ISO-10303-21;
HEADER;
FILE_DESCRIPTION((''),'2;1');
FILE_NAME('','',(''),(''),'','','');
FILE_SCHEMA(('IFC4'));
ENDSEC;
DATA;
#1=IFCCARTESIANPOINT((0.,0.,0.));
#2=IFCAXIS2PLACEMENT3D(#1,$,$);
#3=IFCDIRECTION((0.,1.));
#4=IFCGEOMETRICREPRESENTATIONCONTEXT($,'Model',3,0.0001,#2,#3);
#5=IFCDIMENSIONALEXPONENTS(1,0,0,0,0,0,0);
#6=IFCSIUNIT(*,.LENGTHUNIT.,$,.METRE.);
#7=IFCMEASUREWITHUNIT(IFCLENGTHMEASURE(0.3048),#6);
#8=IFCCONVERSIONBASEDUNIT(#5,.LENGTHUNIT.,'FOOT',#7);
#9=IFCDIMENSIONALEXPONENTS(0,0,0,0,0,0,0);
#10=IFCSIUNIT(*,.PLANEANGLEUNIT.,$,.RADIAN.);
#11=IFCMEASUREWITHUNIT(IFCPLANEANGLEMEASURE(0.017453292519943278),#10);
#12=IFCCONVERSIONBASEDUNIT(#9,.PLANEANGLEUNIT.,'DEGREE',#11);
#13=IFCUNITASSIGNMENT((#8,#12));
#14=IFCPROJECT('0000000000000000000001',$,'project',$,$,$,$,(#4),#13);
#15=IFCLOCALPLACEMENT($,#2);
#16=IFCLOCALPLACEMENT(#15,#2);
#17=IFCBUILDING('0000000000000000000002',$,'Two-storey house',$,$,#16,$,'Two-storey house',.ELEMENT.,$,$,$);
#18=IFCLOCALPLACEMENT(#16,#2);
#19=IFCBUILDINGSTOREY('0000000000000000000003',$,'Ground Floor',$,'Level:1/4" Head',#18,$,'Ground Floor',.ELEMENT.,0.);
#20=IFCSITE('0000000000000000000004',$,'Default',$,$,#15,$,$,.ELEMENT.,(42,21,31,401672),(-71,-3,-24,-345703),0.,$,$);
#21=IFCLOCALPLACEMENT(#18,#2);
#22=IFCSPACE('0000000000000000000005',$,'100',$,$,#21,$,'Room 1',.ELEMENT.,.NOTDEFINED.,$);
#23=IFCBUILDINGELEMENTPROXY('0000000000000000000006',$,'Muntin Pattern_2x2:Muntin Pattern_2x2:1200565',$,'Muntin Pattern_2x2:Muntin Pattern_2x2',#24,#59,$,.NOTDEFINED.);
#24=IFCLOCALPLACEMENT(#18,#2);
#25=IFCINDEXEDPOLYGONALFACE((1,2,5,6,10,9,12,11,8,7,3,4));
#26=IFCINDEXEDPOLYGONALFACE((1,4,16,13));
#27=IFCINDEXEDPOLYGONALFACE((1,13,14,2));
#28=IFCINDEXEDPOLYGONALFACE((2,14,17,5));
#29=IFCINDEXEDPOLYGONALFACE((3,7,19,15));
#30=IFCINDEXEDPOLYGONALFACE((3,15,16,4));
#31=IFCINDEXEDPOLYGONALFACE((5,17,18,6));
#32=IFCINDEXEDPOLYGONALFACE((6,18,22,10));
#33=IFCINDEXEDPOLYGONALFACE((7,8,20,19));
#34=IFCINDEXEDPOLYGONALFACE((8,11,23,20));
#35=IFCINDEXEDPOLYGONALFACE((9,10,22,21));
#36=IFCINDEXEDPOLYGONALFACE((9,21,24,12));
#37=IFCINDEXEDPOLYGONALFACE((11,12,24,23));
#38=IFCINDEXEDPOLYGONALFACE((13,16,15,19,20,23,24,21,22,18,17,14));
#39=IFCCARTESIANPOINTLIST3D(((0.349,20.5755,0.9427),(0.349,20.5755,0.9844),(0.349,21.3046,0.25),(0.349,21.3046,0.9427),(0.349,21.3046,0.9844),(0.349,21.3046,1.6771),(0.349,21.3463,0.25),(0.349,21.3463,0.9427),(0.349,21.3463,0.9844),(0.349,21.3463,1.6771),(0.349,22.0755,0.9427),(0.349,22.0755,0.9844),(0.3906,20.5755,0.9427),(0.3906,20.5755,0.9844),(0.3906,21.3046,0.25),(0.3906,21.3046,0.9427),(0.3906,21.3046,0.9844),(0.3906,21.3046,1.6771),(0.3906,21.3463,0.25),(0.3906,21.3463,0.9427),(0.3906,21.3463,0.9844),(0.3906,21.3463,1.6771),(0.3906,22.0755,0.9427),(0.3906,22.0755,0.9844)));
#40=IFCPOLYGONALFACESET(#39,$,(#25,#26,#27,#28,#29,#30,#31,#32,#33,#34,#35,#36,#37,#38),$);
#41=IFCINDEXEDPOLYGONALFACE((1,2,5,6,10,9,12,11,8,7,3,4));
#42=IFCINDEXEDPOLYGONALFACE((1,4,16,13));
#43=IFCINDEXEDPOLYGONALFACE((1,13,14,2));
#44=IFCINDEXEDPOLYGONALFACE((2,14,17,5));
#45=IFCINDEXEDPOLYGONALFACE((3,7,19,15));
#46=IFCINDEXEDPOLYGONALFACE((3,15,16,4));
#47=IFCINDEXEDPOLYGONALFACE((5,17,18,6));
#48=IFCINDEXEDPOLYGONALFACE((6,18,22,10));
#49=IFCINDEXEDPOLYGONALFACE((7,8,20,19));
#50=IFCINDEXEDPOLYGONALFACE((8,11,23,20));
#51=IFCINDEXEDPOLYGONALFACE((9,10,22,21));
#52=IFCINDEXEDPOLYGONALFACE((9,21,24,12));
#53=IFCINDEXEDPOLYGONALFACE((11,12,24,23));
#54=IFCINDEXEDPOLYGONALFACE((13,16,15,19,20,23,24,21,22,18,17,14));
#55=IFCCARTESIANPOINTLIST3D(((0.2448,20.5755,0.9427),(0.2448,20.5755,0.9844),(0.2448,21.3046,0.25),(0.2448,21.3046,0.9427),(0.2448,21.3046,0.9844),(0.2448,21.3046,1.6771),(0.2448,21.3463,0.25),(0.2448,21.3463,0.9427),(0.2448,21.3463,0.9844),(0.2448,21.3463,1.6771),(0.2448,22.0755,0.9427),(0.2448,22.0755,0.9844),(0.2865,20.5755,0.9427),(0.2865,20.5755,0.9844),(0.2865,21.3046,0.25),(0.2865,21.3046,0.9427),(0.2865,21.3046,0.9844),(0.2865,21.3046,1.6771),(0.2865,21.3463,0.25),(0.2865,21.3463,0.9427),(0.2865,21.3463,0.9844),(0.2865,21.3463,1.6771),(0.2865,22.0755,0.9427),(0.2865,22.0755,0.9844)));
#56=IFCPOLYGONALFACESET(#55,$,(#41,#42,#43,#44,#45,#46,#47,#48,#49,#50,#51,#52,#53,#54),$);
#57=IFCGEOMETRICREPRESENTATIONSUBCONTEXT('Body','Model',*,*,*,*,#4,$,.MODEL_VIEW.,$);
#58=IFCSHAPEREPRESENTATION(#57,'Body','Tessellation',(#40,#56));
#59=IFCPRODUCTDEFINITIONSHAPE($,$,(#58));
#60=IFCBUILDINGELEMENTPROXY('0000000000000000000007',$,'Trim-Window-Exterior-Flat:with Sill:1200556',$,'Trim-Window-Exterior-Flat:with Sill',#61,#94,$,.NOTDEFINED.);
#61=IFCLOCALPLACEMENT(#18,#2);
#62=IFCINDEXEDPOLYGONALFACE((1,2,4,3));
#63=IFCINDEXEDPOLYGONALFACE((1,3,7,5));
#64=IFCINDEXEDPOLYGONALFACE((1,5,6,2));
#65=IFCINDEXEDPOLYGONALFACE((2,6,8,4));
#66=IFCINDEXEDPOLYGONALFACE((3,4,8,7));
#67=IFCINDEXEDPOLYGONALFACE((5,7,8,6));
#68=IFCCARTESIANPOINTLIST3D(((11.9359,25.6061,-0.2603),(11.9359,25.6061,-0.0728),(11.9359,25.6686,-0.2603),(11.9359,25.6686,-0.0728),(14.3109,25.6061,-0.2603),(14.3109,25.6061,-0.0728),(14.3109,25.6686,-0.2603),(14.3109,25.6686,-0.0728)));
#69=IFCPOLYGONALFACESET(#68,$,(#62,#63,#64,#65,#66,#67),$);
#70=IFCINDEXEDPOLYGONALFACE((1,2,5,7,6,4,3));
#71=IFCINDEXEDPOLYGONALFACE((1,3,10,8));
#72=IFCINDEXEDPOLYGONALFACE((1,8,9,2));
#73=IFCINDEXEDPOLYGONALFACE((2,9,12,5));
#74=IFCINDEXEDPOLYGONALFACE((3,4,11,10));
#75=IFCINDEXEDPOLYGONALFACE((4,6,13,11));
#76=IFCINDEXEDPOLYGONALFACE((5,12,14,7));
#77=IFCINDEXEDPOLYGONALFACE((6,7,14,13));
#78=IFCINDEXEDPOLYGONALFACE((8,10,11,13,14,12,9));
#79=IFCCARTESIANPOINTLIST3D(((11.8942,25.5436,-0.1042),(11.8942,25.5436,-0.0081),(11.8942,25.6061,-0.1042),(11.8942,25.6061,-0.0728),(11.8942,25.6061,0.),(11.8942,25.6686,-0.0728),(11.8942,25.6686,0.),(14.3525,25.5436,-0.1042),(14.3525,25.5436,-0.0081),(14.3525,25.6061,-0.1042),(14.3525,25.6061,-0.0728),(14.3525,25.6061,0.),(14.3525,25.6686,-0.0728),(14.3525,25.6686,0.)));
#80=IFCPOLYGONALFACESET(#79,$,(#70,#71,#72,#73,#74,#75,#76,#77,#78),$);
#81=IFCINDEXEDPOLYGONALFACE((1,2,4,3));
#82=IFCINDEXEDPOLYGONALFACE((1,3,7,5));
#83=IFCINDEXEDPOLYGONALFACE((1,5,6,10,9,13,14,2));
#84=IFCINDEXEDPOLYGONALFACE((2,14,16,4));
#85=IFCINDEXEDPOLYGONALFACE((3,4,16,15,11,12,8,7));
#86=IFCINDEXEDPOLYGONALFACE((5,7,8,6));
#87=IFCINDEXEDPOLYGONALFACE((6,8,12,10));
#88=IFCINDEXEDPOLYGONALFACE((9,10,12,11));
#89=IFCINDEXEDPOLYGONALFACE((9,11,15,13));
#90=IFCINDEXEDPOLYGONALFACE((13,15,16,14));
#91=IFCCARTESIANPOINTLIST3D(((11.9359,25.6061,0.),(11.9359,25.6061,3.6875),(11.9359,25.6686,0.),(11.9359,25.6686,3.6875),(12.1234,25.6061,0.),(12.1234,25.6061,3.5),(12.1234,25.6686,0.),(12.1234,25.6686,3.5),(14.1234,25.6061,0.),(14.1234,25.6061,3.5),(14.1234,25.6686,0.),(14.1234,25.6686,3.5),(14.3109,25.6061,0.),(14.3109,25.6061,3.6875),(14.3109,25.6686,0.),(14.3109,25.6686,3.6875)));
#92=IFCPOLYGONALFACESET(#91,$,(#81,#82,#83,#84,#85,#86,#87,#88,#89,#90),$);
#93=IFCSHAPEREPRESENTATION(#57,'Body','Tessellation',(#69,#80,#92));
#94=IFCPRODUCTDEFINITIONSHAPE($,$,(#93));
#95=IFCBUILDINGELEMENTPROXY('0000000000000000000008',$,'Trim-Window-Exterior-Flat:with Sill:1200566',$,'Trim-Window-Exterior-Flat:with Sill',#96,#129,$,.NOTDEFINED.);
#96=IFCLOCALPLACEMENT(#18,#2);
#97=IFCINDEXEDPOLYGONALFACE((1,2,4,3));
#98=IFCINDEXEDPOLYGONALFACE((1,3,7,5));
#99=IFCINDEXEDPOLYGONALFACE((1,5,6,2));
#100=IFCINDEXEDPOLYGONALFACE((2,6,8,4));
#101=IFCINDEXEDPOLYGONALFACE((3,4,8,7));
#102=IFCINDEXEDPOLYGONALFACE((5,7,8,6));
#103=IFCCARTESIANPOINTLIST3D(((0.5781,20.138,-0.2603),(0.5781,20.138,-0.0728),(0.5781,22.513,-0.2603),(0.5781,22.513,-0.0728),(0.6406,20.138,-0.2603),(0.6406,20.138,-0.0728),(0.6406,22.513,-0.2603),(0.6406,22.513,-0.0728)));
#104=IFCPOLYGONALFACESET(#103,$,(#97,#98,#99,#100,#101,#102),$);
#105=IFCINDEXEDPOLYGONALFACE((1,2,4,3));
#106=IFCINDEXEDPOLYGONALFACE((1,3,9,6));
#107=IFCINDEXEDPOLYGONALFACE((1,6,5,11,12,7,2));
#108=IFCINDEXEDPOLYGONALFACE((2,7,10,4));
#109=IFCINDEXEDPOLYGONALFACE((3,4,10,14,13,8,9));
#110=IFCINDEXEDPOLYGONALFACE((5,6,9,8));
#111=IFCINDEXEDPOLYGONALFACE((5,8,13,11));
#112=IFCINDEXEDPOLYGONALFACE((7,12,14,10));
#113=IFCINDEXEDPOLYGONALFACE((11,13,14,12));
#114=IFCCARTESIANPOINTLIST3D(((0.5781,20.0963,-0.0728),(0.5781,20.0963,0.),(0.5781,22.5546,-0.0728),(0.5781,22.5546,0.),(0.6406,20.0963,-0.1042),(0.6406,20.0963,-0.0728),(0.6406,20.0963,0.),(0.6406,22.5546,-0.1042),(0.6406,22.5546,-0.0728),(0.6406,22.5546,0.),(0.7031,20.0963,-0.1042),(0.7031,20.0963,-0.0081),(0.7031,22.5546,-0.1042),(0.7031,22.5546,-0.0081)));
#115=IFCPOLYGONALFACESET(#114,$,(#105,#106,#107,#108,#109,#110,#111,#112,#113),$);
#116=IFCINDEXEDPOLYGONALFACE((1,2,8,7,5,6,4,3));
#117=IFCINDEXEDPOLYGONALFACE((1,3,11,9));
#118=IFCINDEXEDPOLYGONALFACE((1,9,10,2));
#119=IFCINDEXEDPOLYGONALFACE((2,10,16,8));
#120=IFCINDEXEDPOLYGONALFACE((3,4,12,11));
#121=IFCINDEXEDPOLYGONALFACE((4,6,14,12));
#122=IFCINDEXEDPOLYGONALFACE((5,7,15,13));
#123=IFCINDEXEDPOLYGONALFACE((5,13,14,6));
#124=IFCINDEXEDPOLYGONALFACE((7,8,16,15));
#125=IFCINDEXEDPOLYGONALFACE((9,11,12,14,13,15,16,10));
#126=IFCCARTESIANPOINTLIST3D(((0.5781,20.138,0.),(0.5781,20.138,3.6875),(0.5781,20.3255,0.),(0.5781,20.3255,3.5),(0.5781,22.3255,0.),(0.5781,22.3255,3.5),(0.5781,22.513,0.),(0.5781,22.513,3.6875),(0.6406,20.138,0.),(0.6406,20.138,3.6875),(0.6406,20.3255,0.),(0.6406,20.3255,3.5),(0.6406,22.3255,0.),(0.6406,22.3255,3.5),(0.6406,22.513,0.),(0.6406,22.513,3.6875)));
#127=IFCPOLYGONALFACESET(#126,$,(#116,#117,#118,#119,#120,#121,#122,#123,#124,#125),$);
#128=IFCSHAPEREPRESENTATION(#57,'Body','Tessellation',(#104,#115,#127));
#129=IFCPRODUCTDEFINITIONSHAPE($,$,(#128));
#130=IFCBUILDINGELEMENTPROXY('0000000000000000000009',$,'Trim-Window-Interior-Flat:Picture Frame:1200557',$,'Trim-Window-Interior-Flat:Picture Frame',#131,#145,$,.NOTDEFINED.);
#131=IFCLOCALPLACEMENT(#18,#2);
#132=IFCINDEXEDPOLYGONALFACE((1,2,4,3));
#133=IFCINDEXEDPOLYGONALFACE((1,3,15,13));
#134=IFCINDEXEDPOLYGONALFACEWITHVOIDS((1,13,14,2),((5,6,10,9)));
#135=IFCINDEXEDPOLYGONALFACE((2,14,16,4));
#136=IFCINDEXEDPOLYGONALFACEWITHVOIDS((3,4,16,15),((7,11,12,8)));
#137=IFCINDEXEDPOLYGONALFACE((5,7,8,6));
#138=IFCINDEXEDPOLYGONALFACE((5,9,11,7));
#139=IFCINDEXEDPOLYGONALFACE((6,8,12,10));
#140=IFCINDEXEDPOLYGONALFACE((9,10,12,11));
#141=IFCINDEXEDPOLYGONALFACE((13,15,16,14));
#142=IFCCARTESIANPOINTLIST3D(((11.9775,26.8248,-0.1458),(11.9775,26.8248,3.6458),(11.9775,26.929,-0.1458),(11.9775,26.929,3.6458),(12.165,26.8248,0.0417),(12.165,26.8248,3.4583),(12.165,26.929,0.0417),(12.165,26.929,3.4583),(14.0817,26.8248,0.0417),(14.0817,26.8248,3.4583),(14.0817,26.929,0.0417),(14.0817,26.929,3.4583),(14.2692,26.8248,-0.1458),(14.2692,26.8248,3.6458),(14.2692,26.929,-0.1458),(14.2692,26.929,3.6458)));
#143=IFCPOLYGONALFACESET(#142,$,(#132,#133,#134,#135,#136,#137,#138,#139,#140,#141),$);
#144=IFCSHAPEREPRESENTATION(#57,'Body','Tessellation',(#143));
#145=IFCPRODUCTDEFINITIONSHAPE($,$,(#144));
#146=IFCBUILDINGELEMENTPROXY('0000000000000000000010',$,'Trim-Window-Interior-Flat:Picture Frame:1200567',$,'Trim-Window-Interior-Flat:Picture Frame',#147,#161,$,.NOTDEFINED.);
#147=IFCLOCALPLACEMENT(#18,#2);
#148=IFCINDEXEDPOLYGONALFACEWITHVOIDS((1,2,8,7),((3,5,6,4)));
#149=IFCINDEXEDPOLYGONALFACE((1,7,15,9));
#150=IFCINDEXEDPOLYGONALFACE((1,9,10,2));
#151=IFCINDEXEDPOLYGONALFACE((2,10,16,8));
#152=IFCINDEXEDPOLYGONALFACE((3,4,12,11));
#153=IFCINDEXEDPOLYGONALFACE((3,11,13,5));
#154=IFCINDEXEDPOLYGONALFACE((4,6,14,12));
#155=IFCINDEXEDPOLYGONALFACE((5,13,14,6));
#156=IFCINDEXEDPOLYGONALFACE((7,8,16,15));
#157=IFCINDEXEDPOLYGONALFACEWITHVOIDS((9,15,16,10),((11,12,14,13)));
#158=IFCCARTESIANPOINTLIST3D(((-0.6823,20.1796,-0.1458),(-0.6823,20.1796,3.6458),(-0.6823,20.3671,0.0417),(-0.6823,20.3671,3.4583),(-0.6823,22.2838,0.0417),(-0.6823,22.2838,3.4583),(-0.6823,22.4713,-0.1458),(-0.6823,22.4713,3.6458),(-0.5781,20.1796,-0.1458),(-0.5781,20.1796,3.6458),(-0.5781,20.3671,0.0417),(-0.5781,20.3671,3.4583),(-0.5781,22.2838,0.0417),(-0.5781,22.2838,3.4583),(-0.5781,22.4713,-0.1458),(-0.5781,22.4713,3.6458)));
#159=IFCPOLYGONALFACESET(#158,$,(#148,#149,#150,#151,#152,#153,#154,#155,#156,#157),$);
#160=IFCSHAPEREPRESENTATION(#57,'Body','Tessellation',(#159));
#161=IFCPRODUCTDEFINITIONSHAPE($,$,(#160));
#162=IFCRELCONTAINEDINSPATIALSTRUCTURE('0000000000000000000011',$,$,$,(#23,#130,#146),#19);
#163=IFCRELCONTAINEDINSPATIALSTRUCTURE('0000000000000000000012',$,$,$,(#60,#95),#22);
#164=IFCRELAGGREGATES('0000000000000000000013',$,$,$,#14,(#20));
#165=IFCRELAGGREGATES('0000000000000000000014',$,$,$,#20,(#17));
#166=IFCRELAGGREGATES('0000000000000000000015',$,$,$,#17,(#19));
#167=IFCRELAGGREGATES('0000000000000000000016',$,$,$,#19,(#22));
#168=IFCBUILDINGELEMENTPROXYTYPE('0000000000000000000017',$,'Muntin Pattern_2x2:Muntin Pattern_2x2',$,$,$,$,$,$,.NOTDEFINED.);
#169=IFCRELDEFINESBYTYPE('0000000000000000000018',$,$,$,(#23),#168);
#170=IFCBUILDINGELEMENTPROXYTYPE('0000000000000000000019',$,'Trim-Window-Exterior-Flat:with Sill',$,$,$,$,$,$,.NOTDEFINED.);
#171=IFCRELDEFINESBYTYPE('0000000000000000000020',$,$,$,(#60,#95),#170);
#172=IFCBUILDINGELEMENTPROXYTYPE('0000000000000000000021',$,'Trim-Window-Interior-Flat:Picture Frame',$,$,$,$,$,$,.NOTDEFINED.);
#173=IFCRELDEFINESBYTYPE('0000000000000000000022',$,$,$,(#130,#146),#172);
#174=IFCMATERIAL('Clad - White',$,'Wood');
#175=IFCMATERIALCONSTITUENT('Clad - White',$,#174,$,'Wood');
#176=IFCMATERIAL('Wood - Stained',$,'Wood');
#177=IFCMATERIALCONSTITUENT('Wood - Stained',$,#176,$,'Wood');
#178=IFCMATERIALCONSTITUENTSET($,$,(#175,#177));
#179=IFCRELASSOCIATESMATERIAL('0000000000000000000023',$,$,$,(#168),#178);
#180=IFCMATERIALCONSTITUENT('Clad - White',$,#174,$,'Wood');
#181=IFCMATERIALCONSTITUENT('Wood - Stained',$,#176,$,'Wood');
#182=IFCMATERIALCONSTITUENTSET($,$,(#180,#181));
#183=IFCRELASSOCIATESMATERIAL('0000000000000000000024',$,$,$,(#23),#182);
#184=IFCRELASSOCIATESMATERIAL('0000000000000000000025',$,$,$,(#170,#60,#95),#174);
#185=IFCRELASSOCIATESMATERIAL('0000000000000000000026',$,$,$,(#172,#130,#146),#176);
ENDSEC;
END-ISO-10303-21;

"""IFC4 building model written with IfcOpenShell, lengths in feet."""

from ifc_helpers import new_model, entity, si_unit, converted_unit, direction, frame, origin, place, context, subcontext, project, spatial, indexed_curve, outline, extrude, source, transform, mapped, material, constituent, constituent_set, type_object, type_shapes, element, save


model = new_model("IFC4")

# Units and contexts
model_context = context("Model", 3, precision=0.0001, world=origin(), true_north=direction((0.0, 1.0)))
body_context = subcontext(model_context, "Body", "Model", "MODEL_VIEW")
ifc_project = project(units=[converted_unit("LENGTHUNIT", "FOOT", entity("IfcLengthMeasure", 0.3048), si_unit("LENGTHUNIT", "METRE"), dimensions=[1, 0, 0, 0, 0, 0, 0]), converted_unit("PLANEANGLEUNIT", "DEGREE", entity("IfcPlaneAngleMeasure", 0.017453292519943278), si_unit("PLANEANGLEUNIT", "RADIAN"), dimensions=[0, 0, 0, 0, 0, 0, 0])], contexts=[model_context])

# Site, building, storey
site_placement = place(None, origin())
site = spatial("IfcSite", under=ifc_project, at=site_placement, Name="Default", CompositionType="ELEMENT", RefLatitude=(42, 21, 31, 401672), RefLongitude=(-71, -3, -24, -345703), RefElevation=0.0)
building_placement = place(site_placement, origin())
building = spatial("IfcBuilding", under=site, at=building_placement, Name="Two-storey house", LongName="Two-storey house", CompositionType="ELEMENT")
storey_placement = place(building_placement, origin())
storey = spatial("IfcBuildingStorey", under=building, at=storey_placement, Name="Ground Floor", ObjectType="Level:1/4\" Head", LongName="Ground Floor", CompositionType="ELEMENT", Elevation=0.0)

# Shared definitions
ifc_material_1 = material(Name="Wood - Stained", Category="Wood")

# Building element proxy
ifc_material_2 = material(Name="Clad - White", Category="Wood")
ifc_constituent_1 = constituent(ifc_material_2, Name="Clad - White", Category="Wood")
ifc_constituent_2 = constituent(ifc_material_1, Name="Wood - Stained", Category="Wood")
ifc_constituent_set_1 = constituent_set(constituents=[ifc_constituent_1, ifc_constituent_2])
building_element_proxy_type_1 = type_object("IfcBuildingElementProxyType", Name="Muntin Pattern_2x2:Muntin Pattern_2x2", PredefinedType="NOTDEFINED", material=ifc_constituent_set_1)
shared_shape_1 = source(origin(), body_context, "Body", "SweptSolid", [
    extrude(outline(indexed_curve([(0.0208, -0.0208), (0.7135, -0.0208), (0.7135, 0.0208), (0.0208, 0.0208), (0.0208, 0.75), (-0.0208, 0.75), (-0.0208, 0.0208), (-0.7135, 0.0208), (-0.7135, -0.0208), (-0.0208, -0.0208), (-0.0208, -0.75), (0.0208, -0.75), (0.0208, -0.0208)], self_intersect=False)), frame((0.0, 0.0312, 0.7135), z_axis=(0.0, 1.0, 0.0), x_axis=(0.0, 0.0, 1.0)), (0.0, 0.0, 1.0), 0.0417),
    extrude(outline(indexed_curve([(0.0208, -0.0208), (0.7135, -0.0208), (0.7135, 0.0208), (0.0208, 0.0208), (0.0208, 0.75), (-0.0208, 0.75), (-0.0208, 0.0208), (-0.7135, 0.0208), (-0.7135, -0.0208), (-0.0208, -0.0208), (-0.0208, -0.75), (0.0208, -0.75), (0.0208, -0.0208)], self_intersect=False)), frame((0.0, -0.0729, 0.7135), z_axis=(0.0, 1.0, 0.0), x_axis=(0.0, 0.0, 1.0)), (0.0, 0.0, 1.0), 0.0417),
])
type_shapes(building_element_proxy_type_1, [shared_shape_1])
ifc_constituent_3 = constituent(ifc_material_2, Name="Clad - White", Category="Wood")
ifc_constituent_4 = constituent(ifc_material_1, Name="Wood - Stained", Category="Wood")
ifc_constituent_set_2 = constituent_set(constituents=[ifc_constituent_3, ifc_constituent_4])
proxy_1_placement = place(storey_placement, frame((0.3177, 21.3255, 0.25), z_axis=(0.0, 0.0, 1.0), x_axis=(0.0, -1.0, 0.0)))
element("IfcBuildingElementProxy", 1, at=proxy_1_placement, inside=storey, type_object=building_element_proxy_type_1, material=ifc_constituent_set_2, Name="Muntin Pattern_2x2:Muntin Pattern_2x2:1200565", ObjectType="Muntin Pattern_2x2:Muntin Pattern_2x2", PredefinedType="NOTDEFINED", context=body_context, shape_type="MappedRepresentation", body=[
    mapped(shared_shape_1, transform((0.0, 0.0, 0.0), scale=1.0)),
])

# Shared definitions
space_placement = place(storey_placement, origin())
space = spatial("IfcSpace", under=storey, at=space_placement, Name="100", LongName="Room 1", CompositionType="ELEMENT", PredefinedType="NOTDEFINED")

# Building element proxies
building_element_proxy_type_2 = type_object("IfcBuildingElementProxyType", Name="Trim-Window-Exterior-Flat:with Sill", PredefinedType="NOTDEFINED", material=ifc_material_2)
shared_shape_2 = source(origin(), body_context, "Body", "SweptSolid", [
    extrude(outline(indexed_curve([(-1.1875, -0.0938), (1.1875, -0.0938), (1.1875, 0.0938), (-1.1875, 0.0938), (-1.1875, -0.0938)], self_intersect=False)), frame((0.0, -3.6665, 0.0), z_axis=(0.0, 0.0, 1.0), x_axis=(-1.0, 0.0, 0.0)), (0.0, 0.0, 1.0), 0.0625),
    extrude(outline(indexed_curve([(-0.0625, -0.0525), (0.0, -0.0525), (0.0, -0.0211), (0.0625, -0.0211), (0.0625, 0.0517), (0.0, 0.0517), (-0.0625, 0.0436), (-0.0625, -0.0525)], self_intersect=False)), frame((-1.2292, -3.5517, 0.0625), z_axis=(1.0, 0.0, 0.0), x_axis=(0.0, 0.0, -1.0)), (0.0, 0.0, 1.0), 2.4583),
    extrude(outline(indexed_curve([(-1.8906, -1.1875), (1.7969, -1.1875), (1.7969, -1.0), (-1.7031, -1.0), (-1.7031, 1.0), (1.7969, 1.0), (1.7969, 1.1875), (-1.8906, 1.1875), (-1.8906, -1.1875)], self_intersect=False)), frame((0.0, -1.7031, 0.0), z_axis=(0.0, 0.0, 1.0), x_axis=(0.0, -1.0, 0.0)), (0.0, 0.0, 1.0), 0.0625),
])
type_shapes(building_element_proxy_type_2, [shared_shape_2])
for number, where, z_axis, x_axis, name in (
    (2, (13.1234, 25.6686, 3.5), (0.0, -1.0, 0.0), (1.0, 0.0, 0.0), "Trim-Window-Exterior-Flat:with Sill:1200556"),
    (3, (0.5781, 21.3255, 3.5), (1.0, 0.0, 0.0), (0.0, 1.0, 0.0), "Trim-Window-Exterior-Flat:with Sill:1200566"),
):
    element("IfcBuildingElementProxy", number, at=place(space_placement, frame(where, z_axis=z_axis, x_axis=x_axis)), inside=space, type_object=building_element_proxy_type_2, material=ifc_material_2, Name=name, ObjectType="Trim-Window-Exterior-Flat:with Sill", PredefinedType="NOTDEFINED", context=body_context, shape_type="MappedRepresentation", body=[
        mapped(shared_shape_2, transform((0.0, 0.0, 0.0), scale=1.0)),
    ])
building_element_proxy_type_3 = type_object("IfcBuildingElementProxyType", Name="Trim-Window-Interior-Flat:Picture Frame", PredefinedType="NOTDEFINED", material=ifc_material_1)
shared_shape_3 = source(origin(), body_context, "Body", "SweptSolid", [
    extrude(outline(indexed_curve([(-1.1458, -1.8958), (1.1458, -1.8958), (1.1458, 1.8958), (-1.1458, 1.8958), (-1.1458, -1.8958)], self_intersect=False), holes=[indexed_curve([(-0.9583, -1.7083), (-0.9583, 1.7083), (0.9583, 1.7083), (0.9583, -1.7083), (-0.9583, -1.7083)], self_intersect=False)]), frame((0.0, -1.75, 0.0), z_axis=(0.0, 0.0, 1.0), x_axis=(-1.0, 0.0, 0.0)), (0.0, 0.0, 1.0), 0.1042),
])
type_shapes(building_element_proxy_type_3, [shared_shape_3])
for number, where, z_axis, x_axis, name in (
    (4, (13.1234, 26.8248, 3.5), (0.0, 1.0, 0.0), (-1.0, 0.0, 0.0), "Trim-Window-Interior-Flat:Picture Frame:1200557"),
    (5, (-0.5781, 21.3255, 3.5), (-1.0, 0.0, 0.0), (0.0, -1.0, 0.0), "Trim-Window-Interior-Flat:Picture Frame:1200567"),
):
    element("IfcBuildingElementProxy", number, at=place(storey_placement, frame(where, z_axis=z_axis, x_axis=x_axis)), inside=storey, type_object=building_element_proxy_type_3, material=ifc_material_1, Name=name, ObjectType="Trim-Window-Interior-Flat:Picture Frame", PredefinedType="NOTDEFINED", context=body_context, shape_type="MappedRepresentation", body=[
        mapped(shared_shape_3, transform((0.0, 0.0, 0.0), scale=1.0)),
    ])

save(model, "model.ifc")
